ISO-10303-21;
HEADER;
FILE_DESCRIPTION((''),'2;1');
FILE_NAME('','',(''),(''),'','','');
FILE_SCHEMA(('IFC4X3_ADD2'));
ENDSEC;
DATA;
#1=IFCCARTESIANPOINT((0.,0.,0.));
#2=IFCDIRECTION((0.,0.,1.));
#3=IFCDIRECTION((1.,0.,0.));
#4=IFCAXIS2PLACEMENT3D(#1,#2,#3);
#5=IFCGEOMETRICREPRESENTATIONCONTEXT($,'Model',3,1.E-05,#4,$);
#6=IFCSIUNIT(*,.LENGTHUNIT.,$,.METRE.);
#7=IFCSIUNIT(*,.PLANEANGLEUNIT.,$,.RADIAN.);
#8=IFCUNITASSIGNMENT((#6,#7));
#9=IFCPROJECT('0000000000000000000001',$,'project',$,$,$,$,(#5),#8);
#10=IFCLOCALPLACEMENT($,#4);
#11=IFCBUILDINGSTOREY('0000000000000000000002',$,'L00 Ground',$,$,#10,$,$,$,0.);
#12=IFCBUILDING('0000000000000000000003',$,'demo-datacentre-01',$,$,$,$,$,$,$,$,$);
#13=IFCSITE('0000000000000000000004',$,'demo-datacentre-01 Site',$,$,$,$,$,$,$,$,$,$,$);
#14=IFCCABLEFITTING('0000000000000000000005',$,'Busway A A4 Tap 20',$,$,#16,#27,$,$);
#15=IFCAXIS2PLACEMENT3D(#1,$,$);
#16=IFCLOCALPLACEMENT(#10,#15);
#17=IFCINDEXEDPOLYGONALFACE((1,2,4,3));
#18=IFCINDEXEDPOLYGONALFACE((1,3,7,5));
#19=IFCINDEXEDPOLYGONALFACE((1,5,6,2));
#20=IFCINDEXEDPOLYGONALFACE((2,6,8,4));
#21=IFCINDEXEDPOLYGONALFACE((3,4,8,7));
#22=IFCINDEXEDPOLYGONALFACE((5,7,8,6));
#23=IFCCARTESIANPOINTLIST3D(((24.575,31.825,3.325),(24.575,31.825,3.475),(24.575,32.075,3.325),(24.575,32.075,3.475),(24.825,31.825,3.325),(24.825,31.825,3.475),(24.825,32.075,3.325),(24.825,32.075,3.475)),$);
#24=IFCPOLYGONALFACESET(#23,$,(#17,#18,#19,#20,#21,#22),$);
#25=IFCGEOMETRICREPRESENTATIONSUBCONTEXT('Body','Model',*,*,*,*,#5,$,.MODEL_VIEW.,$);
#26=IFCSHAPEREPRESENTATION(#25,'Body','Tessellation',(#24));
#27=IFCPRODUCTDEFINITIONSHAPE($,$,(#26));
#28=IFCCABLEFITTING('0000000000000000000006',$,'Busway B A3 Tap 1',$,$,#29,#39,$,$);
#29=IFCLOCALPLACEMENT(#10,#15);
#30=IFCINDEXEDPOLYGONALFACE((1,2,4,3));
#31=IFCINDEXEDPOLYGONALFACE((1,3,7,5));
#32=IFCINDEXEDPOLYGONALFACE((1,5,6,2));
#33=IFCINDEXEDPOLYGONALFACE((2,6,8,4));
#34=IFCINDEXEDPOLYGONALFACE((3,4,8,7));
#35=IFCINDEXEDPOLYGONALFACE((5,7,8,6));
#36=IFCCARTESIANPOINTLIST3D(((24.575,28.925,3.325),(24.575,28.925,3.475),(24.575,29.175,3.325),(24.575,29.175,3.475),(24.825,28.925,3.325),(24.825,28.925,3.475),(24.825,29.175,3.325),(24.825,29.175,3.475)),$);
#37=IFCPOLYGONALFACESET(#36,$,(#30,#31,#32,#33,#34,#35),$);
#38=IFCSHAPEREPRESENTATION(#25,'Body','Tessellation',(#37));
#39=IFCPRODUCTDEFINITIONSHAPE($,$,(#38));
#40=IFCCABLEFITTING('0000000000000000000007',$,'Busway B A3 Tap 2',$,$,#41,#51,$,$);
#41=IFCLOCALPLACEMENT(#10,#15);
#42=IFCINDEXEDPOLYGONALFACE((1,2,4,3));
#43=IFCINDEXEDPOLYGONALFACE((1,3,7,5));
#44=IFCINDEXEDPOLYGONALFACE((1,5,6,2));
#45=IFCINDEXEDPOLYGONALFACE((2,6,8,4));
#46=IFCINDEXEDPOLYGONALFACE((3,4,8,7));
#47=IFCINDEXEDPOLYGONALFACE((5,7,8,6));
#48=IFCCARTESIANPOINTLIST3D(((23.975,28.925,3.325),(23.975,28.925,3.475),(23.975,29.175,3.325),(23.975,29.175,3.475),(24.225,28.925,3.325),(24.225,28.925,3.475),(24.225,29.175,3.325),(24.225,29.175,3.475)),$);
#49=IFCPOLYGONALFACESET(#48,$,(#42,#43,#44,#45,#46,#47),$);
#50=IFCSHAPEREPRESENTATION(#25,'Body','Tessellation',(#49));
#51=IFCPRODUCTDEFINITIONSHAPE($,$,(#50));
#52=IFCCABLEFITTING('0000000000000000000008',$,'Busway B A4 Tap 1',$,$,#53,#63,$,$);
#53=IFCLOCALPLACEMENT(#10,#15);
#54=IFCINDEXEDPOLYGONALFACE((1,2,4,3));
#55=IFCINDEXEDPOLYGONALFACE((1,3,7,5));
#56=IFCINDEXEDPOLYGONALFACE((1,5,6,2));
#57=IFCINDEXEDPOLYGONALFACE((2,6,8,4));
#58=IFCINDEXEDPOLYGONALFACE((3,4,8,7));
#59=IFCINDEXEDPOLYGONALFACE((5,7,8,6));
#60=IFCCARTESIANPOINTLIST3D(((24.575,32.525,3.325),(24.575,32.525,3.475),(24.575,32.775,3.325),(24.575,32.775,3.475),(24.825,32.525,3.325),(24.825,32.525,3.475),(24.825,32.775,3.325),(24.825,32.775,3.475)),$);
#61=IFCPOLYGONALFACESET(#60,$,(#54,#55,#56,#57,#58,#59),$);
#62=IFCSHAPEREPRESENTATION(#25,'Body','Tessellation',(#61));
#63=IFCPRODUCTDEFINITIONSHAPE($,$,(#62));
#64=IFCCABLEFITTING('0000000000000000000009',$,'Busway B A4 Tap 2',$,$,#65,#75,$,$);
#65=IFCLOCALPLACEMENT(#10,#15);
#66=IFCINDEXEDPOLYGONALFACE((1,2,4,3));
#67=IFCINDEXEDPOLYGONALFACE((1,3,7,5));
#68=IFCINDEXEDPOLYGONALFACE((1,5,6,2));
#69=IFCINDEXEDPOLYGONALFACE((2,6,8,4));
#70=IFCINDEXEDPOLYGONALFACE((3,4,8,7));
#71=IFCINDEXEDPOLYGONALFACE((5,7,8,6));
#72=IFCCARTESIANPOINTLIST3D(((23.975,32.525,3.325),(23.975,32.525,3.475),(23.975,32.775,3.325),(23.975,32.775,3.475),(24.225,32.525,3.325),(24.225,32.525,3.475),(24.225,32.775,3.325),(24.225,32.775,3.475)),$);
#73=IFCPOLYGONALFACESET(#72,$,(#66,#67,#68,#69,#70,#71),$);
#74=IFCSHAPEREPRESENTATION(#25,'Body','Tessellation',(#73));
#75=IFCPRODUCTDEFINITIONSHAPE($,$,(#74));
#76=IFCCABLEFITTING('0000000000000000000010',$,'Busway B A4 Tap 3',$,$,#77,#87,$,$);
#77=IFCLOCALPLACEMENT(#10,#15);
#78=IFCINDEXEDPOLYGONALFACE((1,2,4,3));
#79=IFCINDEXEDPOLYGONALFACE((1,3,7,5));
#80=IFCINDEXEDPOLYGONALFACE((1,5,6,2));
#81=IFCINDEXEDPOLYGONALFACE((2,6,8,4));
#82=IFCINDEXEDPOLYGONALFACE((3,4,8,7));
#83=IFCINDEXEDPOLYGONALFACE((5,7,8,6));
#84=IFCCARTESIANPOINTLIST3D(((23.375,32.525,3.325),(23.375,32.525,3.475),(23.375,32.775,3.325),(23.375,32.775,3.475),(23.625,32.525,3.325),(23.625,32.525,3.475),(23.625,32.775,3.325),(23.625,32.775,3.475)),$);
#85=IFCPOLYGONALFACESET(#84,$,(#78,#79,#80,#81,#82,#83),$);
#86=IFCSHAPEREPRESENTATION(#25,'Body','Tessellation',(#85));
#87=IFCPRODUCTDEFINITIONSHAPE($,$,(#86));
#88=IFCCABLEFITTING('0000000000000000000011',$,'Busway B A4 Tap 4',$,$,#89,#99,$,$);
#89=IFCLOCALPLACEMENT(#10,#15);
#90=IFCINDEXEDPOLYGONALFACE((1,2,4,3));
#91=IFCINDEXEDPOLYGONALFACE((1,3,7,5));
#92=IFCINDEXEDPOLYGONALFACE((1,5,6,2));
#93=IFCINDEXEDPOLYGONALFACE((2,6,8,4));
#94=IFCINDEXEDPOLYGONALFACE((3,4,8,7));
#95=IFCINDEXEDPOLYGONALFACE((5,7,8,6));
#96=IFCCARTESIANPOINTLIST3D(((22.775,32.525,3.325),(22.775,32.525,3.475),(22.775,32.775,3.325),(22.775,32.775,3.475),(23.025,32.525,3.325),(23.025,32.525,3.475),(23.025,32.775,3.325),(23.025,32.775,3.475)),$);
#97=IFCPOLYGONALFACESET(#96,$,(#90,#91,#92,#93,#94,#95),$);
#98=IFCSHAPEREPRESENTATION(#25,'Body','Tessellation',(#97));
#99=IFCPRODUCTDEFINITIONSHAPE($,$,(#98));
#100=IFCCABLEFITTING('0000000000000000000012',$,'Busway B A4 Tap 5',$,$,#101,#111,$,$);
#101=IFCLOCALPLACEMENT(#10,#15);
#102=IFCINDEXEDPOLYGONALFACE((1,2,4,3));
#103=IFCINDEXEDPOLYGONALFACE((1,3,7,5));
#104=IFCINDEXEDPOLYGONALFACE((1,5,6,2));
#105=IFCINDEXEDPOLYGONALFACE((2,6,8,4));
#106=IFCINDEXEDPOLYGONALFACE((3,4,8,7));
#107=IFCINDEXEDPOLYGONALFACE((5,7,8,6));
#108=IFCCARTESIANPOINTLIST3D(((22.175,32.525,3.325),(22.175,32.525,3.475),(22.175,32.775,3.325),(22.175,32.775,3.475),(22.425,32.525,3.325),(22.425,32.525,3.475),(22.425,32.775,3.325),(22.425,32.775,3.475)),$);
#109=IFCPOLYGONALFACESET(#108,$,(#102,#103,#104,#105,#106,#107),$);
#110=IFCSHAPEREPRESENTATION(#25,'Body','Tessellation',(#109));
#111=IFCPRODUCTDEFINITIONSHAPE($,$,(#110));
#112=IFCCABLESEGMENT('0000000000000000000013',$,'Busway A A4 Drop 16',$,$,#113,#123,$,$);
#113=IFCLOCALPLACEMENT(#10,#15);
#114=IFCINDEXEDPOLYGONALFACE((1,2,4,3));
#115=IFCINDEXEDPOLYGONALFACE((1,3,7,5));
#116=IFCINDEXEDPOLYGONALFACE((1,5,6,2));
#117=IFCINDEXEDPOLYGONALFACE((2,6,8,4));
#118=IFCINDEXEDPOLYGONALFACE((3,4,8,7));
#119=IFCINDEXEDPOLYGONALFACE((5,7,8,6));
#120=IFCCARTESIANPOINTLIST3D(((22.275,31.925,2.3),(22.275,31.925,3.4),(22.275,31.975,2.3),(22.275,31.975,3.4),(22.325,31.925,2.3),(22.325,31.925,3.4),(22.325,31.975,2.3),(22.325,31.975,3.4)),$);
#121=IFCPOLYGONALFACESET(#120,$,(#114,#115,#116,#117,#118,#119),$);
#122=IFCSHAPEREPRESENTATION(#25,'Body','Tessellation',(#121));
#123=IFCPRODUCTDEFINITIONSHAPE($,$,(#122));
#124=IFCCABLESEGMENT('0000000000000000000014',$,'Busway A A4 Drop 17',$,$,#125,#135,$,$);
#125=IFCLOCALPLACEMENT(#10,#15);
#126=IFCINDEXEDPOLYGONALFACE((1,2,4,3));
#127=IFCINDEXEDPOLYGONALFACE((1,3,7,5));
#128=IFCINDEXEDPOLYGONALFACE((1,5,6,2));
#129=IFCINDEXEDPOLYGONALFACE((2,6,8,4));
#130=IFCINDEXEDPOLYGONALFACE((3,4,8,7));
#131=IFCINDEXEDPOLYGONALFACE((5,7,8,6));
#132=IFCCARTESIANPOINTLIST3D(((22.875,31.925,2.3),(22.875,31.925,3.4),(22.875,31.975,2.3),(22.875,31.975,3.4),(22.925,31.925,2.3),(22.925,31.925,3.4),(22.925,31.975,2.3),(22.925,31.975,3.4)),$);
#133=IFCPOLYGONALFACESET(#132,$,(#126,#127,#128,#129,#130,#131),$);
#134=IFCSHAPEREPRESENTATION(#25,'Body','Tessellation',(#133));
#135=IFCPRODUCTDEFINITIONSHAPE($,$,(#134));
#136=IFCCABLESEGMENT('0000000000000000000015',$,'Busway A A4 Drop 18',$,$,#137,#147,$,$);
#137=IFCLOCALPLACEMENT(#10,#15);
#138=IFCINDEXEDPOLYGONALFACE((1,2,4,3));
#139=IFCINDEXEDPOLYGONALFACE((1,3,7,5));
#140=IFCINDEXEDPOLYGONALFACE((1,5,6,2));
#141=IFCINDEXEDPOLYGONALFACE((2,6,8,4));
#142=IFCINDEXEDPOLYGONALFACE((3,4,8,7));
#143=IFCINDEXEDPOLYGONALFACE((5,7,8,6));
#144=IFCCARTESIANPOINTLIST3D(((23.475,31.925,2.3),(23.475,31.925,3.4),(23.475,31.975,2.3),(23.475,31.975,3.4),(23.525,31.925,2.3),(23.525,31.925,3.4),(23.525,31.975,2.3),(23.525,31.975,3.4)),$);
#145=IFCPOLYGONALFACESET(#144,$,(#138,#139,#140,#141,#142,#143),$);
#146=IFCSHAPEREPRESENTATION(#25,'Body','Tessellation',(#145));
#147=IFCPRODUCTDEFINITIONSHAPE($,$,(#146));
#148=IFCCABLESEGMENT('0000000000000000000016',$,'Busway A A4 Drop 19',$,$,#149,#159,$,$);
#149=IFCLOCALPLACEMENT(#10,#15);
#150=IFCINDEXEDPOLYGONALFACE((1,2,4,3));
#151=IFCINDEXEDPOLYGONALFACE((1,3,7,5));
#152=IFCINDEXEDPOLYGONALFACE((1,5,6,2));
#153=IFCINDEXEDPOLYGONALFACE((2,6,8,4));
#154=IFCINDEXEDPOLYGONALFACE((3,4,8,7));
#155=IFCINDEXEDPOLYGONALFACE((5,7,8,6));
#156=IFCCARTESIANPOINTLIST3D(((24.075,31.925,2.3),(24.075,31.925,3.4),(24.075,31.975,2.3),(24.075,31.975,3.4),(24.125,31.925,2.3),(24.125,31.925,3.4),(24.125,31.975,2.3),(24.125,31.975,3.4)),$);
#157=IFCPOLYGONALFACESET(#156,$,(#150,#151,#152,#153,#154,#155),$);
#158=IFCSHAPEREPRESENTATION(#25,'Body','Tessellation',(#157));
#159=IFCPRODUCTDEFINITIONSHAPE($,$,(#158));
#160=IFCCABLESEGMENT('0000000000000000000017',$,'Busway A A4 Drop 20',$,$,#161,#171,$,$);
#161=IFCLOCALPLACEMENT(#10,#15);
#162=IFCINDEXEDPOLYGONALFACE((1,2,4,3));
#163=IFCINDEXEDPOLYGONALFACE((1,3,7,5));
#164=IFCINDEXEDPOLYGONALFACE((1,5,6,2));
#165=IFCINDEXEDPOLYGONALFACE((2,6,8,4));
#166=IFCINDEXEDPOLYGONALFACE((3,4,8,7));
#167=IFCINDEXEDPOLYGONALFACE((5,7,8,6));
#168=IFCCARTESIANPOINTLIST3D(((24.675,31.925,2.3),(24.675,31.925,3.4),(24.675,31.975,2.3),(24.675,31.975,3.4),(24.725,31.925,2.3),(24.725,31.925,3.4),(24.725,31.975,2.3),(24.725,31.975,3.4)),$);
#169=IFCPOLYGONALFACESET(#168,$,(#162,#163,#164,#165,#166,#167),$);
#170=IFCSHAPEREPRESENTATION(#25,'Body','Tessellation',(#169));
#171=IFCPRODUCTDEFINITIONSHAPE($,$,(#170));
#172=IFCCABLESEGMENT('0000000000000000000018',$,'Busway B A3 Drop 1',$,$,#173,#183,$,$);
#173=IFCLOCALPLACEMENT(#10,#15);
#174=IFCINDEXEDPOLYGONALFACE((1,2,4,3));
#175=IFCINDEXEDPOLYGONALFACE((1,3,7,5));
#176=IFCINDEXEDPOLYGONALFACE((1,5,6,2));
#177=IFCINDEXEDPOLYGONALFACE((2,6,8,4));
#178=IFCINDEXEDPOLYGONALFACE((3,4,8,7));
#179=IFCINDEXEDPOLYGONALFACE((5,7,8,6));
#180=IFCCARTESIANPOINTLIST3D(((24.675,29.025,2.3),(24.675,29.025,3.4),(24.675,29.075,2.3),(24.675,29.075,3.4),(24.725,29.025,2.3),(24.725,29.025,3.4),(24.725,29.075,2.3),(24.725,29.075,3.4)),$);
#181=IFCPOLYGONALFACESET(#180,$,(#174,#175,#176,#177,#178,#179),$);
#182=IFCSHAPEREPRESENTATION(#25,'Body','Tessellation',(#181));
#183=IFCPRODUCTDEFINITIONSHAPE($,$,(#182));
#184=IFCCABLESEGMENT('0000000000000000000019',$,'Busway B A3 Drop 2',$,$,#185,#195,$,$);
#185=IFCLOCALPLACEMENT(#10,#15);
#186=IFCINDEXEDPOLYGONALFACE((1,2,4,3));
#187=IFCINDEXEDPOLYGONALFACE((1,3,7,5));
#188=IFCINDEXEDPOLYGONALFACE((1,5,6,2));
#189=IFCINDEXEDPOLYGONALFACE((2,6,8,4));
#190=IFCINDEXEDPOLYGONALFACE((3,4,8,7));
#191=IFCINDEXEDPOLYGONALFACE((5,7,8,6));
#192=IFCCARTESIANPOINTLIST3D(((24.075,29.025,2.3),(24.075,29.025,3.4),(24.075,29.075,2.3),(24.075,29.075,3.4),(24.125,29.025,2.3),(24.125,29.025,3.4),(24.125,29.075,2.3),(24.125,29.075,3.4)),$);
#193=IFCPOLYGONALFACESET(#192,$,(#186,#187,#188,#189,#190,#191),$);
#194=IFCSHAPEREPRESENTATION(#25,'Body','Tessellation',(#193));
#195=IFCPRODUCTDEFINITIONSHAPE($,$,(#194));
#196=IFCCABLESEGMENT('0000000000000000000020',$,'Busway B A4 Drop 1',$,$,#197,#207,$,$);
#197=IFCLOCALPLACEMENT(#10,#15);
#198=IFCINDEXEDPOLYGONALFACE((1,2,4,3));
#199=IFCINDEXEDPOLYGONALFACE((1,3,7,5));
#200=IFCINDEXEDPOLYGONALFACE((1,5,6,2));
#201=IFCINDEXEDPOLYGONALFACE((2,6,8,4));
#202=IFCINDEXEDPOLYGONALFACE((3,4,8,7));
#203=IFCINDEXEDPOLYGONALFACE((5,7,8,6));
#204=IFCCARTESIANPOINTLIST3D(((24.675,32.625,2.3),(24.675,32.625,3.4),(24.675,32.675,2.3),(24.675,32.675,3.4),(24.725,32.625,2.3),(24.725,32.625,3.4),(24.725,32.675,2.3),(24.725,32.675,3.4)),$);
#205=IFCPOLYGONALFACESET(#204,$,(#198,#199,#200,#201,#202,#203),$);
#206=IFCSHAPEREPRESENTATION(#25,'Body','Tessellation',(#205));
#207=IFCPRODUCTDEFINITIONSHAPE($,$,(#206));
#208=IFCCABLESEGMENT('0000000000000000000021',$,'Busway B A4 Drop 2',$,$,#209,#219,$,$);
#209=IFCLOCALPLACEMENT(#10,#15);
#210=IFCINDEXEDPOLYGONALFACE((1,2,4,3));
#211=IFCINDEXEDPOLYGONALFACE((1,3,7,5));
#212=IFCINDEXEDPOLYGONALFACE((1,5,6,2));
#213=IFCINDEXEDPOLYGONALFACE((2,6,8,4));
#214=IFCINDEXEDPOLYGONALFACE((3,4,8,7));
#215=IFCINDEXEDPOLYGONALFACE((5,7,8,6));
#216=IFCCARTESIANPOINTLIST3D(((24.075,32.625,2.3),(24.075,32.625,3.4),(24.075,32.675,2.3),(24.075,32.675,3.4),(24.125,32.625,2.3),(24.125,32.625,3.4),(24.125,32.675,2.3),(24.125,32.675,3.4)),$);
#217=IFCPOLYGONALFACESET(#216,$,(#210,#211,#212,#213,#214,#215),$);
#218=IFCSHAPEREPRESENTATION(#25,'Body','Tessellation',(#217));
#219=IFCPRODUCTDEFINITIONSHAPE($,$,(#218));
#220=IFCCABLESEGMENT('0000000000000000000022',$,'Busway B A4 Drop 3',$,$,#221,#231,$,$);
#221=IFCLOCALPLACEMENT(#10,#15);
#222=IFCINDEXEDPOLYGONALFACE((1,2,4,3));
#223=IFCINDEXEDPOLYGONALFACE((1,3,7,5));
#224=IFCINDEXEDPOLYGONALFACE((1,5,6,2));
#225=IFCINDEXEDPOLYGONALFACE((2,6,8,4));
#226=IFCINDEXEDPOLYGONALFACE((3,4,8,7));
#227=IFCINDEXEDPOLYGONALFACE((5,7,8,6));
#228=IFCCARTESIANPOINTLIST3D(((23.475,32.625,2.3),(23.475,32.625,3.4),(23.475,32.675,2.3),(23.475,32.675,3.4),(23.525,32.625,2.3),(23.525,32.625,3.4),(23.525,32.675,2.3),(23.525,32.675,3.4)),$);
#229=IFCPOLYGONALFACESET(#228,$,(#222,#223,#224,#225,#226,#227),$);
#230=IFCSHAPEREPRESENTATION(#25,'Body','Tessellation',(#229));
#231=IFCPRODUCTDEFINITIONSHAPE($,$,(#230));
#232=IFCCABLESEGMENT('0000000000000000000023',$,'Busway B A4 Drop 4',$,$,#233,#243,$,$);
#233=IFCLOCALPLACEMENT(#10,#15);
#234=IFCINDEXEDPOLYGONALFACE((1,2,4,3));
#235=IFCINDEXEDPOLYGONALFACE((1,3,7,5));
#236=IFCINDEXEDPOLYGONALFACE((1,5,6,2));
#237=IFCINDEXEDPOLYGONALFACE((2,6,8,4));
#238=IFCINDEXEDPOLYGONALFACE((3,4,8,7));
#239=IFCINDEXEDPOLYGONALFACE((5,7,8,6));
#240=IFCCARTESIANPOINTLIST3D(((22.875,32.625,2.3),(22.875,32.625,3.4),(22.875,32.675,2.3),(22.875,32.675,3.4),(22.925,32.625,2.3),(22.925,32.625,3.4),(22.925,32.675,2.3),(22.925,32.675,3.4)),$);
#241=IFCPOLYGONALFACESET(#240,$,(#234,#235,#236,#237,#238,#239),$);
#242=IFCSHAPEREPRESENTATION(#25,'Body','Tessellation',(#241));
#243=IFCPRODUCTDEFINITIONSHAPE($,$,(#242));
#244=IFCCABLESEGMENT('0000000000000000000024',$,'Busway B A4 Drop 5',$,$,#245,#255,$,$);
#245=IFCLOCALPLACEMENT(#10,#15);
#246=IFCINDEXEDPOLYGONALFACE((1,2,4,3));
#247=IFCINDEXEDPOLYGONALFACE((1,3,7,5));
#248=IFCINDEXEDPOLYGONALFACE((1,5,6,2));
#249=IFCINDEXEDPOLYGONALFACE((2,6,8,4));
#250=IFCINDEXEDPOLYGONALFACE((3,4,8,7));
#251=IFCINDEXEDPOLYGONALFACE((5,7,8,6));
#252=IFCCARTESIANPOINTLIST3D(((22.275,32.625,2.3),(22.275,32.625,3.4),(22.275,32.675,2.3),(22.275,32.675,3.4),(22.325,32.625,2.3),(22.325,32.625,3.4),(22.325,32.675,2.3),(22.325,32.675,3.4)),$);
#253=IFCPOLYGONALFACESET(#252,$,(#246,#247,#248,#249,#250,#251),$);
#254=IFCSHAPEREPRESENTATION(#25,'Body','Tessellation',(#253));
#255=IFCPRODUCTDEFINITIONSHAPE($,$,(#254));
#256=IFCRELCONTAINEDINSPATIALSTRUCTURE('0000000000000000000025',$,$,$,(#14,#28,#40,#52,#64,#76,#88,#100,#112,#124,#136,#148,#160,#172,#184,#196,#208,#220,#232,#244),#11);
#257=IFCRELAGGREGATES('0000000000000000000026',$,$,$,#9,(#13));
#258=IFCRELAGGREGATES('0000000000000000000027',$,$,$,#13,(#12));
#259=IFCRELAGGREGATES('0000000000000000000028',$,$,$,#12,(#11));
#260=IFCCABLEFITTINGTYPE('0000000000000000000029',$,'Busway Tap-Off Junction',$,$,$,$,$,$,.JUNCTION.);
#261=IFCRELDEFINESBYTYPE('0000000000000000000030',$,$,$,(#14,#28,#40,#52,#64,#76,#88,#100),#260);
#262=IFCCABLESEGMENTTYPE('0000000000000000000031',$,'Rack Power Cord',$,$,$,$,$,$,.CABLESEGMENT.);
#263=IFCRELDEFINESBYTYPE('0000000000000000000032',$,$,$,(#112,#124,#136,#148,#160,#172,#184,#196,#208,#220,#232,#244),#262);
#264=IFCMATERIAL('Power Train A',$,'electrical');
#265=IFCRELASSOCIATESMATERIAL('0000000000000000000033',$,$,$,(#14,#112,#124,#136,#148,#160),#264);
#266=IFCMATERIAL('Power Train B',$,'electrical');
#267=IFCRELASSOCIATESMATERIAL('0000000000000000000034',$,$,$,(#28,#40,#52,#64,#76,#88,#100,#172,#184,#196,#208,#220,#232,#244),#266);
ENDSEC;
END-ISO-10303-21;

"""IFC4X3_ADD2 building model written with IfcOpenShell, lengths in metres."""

from ifc_helpers import new_model, si_unit, frame, origin_with_axes, place, context, subcontext, project, spatial, rectangle, extrude, material, type_object, element, save


model = new_model("IFC4X3_ADD2")

# Units and contexts
model_context = context("Model", 3, precision=1e-05, world=origin_with_axes())
body_context = subcontext(model_context, "Body", "Model", "MODEL_VIEW")
ifc_project = project(units=[si_unit("LENGTHUNIT", "METRE"), si_unit("PLANEANGLEUNIT", "RADIAN")], contexts=[model_context])

# Site, building, storey
site = spatial("IfcSite", under=ifc_project, Name="demo-datacentre-01 Site")
building = spatial("IfcBuilding", under=site, Name="demo-datacentre-01")
storey_placement = place(None, origin_with_axes())
storey = spatial("IfcBuildingStorey", under=building, at=storey_placement, Name="L00 Ground", Elevation=0.0)

# Shared definitions
ifc_material_1 = material(Name="Power Train B", Category="electrical")

# Shared definitions
ifc_material_2 = material(Name="Power Train A", Category="electrical")

# Cable fittings
cable_fitting_type = type_object("IfcCableFittingType", Name="Busway Tap-Off Junction", PredefinedType="JUNCTION")
for number, where, z_axis, x_axis, name in (
    (1, (24.7, 31.95, 3.325), (0.0, 0.0, 1.0), (1.0, 0.0, 0.0), "Busway A A4 Tap 20"),
):
    element("IfcCableFitting", number, at=place(storey_placement, frame(where, z_axis=z_axis, x_axis=x_axis)), inside=storey, type_object=cable_fitting_type, material=ifc_material_2, Name=name, context=body_context, shape_type="SweptSolid", body=[
        extrude(rectangle(XDim=0.25, YDim=0.25), origin_with_axes(), (0.0, 0.0, 1.0), 0.15),
    ])
for number, where, z_axis, x_axis, name in (
    (2, (24.7, 29.05, 3.325), (0.0, 0.0, 1.0), (1.0, 0.0, 0.0), "Busway B A3 Tap 1"),
    (3, (24.1, 29.05, 3.325), (0.0, 0.0, 1.0), (1.0, 0.0, 0.0), "Busway B A3 Tap 2"),
    (4, (24.7, 32.65, 3.325), (0.0, 0.0, 1.0), (1.0, 0.0, 0.0), "Busway B A4 Tap 1"),
    (5, (24.1, 32.65, 3.325), (0.0, 0.0, 1.0), (1.0, 0.0, 0.0), "Busway B A4 Tap 2"),
    (6, (23.5, 32.65, 3.325), (0.0, 0.0, 1.0), (1.0, 0.0, 0.0), "Busway B A4 Tap 3"),
    (7, (22.9, 32.65, 3.325), (0.0, 0.0, 1.0), (1.0, 0.0, 0.0), "Busway B A4 Tap 4"),
    (8, (22.3, 32.65, 3.325), (0.0, 0.0, 1.0), (1.0, 0.0, 0.0), "Busway B A4 Tap 5"),
):
    element("IfcCableFitting", number, at=place(storey_placement, frame(where, z_axis=z_axis, x_axis=x_axis)), inside=storey, type_object=cable_fitting_type, material=ifc_material_1, Name=name, context=body_context, shape_type="SweptSolid", body=[
        extrude(rectangle(XDim=0.25, YDim=0.25), origin_with_axes(), (0.0, 0.0, 1.0), 0.15),
    ])

# Cable segments
cable_segment_type_1 = type_object("IfcCableSegmentType", Name="Rack Power Cord", PredefinedType="CABLESEGMENT")
for number, where, z_axis, x_axis, name in (
    (9, (22.3, 31.95, 3.4), (0.0, 0.0, -1.0), (1.0, 0.0, 0.0), "Busway A A4 Drop 16"),
    (10, (22.9, 31.95, 3.4), (0.0, 0.0, -1.0), (1.0, 0.0, 0.0), "Busway A A4 Drop 17"),
    (11, (23.5, 31.95, 3.4), (0.0, 0.0, -1.0), (1.0, 0.0, 0.0), "Busway A A4 Drop 18"),
    (12, (24.1, 31.95, 3.4), (0.0, 0.0, -1.0), (1.0, 0.0, 0.0), "Busway A A4 Drop 19"),
    (13, (24.7, 31.95, 3.4), (0.0, 0.0, -1.0), (1.0, 0.0, 0.0), "Busway A A4 Drop 20"),
):
    element("IfcCableSegment", number, at=place(storey_placement, frame(where, z_axis=z_axis, x_axis=x_axis)), inside=storey, type_object=cable_segment_type_1, material=ifc_material_2, Name=name, context=body_context, shape_type="SweptSolid", body=[
        extrude(rectangle(XDim=0.05, YDim=0.05), origin_with_axes(), (0.0, 0.0, 1.0), 1.1),
    ])
for number, where, z_axis, x_axis, name in (
    (14, (24.7, 29.05, 3.4), (0.0, 0.0, -1.0), (1.0, 0.0, 0.0), "Busway B A3 Drop 1"),
    (15, (24.1, 29.05, 3.4), (0.0, 0.0, -1.0), (1.0, 0.0, 0.0), "Busway B A3 Drop 2"),
    (16, (24.7, 32.65, 3.4), (0.0, 0.0, -1.0), (1.0, 0.0, 0.0), "Busway B A4 Drop 1"),
    (17, (24.1, 32.65, 3.4), (0.0, 0.0, -1.0), (1.0, 0.0, 0.0), "Busway B A4 Drop 2"),
    (18, (23.5, 32.65, 3.4), (0.0, 0.0, -1.0), (1.0, 0.0, 0.0), "Busway B A4 Drop 3"),
    (19, (22.9, 32.65, 3.4), (0.0, 0.0, -1.0), (1.0, 0.0, 0.0), "Busway B A4 Drop 4"),
    (20, (22.3, 32.65, 3.4), (0.0, 0.0, -1.0), (1.0, 0.0, 0.0), "Busway B A4 Drop 5"),
):
    element("IfcCableSegment", number, at=place(storey_placement, frame(where, z_axis=z_axis, x_axis=x_axis)), inside=storey, type_object=cable_segment_type_1, material=ifc_material_1, Name=name, context=body_context, shape_type="SweptSolid", body=[
        extrude(rectangle(XDim=0.05, YDim=0.05), origin_with_axes(), (0.0, 0.0, 1.0), 1.1),
    ])

save(model, "model.ifc")
